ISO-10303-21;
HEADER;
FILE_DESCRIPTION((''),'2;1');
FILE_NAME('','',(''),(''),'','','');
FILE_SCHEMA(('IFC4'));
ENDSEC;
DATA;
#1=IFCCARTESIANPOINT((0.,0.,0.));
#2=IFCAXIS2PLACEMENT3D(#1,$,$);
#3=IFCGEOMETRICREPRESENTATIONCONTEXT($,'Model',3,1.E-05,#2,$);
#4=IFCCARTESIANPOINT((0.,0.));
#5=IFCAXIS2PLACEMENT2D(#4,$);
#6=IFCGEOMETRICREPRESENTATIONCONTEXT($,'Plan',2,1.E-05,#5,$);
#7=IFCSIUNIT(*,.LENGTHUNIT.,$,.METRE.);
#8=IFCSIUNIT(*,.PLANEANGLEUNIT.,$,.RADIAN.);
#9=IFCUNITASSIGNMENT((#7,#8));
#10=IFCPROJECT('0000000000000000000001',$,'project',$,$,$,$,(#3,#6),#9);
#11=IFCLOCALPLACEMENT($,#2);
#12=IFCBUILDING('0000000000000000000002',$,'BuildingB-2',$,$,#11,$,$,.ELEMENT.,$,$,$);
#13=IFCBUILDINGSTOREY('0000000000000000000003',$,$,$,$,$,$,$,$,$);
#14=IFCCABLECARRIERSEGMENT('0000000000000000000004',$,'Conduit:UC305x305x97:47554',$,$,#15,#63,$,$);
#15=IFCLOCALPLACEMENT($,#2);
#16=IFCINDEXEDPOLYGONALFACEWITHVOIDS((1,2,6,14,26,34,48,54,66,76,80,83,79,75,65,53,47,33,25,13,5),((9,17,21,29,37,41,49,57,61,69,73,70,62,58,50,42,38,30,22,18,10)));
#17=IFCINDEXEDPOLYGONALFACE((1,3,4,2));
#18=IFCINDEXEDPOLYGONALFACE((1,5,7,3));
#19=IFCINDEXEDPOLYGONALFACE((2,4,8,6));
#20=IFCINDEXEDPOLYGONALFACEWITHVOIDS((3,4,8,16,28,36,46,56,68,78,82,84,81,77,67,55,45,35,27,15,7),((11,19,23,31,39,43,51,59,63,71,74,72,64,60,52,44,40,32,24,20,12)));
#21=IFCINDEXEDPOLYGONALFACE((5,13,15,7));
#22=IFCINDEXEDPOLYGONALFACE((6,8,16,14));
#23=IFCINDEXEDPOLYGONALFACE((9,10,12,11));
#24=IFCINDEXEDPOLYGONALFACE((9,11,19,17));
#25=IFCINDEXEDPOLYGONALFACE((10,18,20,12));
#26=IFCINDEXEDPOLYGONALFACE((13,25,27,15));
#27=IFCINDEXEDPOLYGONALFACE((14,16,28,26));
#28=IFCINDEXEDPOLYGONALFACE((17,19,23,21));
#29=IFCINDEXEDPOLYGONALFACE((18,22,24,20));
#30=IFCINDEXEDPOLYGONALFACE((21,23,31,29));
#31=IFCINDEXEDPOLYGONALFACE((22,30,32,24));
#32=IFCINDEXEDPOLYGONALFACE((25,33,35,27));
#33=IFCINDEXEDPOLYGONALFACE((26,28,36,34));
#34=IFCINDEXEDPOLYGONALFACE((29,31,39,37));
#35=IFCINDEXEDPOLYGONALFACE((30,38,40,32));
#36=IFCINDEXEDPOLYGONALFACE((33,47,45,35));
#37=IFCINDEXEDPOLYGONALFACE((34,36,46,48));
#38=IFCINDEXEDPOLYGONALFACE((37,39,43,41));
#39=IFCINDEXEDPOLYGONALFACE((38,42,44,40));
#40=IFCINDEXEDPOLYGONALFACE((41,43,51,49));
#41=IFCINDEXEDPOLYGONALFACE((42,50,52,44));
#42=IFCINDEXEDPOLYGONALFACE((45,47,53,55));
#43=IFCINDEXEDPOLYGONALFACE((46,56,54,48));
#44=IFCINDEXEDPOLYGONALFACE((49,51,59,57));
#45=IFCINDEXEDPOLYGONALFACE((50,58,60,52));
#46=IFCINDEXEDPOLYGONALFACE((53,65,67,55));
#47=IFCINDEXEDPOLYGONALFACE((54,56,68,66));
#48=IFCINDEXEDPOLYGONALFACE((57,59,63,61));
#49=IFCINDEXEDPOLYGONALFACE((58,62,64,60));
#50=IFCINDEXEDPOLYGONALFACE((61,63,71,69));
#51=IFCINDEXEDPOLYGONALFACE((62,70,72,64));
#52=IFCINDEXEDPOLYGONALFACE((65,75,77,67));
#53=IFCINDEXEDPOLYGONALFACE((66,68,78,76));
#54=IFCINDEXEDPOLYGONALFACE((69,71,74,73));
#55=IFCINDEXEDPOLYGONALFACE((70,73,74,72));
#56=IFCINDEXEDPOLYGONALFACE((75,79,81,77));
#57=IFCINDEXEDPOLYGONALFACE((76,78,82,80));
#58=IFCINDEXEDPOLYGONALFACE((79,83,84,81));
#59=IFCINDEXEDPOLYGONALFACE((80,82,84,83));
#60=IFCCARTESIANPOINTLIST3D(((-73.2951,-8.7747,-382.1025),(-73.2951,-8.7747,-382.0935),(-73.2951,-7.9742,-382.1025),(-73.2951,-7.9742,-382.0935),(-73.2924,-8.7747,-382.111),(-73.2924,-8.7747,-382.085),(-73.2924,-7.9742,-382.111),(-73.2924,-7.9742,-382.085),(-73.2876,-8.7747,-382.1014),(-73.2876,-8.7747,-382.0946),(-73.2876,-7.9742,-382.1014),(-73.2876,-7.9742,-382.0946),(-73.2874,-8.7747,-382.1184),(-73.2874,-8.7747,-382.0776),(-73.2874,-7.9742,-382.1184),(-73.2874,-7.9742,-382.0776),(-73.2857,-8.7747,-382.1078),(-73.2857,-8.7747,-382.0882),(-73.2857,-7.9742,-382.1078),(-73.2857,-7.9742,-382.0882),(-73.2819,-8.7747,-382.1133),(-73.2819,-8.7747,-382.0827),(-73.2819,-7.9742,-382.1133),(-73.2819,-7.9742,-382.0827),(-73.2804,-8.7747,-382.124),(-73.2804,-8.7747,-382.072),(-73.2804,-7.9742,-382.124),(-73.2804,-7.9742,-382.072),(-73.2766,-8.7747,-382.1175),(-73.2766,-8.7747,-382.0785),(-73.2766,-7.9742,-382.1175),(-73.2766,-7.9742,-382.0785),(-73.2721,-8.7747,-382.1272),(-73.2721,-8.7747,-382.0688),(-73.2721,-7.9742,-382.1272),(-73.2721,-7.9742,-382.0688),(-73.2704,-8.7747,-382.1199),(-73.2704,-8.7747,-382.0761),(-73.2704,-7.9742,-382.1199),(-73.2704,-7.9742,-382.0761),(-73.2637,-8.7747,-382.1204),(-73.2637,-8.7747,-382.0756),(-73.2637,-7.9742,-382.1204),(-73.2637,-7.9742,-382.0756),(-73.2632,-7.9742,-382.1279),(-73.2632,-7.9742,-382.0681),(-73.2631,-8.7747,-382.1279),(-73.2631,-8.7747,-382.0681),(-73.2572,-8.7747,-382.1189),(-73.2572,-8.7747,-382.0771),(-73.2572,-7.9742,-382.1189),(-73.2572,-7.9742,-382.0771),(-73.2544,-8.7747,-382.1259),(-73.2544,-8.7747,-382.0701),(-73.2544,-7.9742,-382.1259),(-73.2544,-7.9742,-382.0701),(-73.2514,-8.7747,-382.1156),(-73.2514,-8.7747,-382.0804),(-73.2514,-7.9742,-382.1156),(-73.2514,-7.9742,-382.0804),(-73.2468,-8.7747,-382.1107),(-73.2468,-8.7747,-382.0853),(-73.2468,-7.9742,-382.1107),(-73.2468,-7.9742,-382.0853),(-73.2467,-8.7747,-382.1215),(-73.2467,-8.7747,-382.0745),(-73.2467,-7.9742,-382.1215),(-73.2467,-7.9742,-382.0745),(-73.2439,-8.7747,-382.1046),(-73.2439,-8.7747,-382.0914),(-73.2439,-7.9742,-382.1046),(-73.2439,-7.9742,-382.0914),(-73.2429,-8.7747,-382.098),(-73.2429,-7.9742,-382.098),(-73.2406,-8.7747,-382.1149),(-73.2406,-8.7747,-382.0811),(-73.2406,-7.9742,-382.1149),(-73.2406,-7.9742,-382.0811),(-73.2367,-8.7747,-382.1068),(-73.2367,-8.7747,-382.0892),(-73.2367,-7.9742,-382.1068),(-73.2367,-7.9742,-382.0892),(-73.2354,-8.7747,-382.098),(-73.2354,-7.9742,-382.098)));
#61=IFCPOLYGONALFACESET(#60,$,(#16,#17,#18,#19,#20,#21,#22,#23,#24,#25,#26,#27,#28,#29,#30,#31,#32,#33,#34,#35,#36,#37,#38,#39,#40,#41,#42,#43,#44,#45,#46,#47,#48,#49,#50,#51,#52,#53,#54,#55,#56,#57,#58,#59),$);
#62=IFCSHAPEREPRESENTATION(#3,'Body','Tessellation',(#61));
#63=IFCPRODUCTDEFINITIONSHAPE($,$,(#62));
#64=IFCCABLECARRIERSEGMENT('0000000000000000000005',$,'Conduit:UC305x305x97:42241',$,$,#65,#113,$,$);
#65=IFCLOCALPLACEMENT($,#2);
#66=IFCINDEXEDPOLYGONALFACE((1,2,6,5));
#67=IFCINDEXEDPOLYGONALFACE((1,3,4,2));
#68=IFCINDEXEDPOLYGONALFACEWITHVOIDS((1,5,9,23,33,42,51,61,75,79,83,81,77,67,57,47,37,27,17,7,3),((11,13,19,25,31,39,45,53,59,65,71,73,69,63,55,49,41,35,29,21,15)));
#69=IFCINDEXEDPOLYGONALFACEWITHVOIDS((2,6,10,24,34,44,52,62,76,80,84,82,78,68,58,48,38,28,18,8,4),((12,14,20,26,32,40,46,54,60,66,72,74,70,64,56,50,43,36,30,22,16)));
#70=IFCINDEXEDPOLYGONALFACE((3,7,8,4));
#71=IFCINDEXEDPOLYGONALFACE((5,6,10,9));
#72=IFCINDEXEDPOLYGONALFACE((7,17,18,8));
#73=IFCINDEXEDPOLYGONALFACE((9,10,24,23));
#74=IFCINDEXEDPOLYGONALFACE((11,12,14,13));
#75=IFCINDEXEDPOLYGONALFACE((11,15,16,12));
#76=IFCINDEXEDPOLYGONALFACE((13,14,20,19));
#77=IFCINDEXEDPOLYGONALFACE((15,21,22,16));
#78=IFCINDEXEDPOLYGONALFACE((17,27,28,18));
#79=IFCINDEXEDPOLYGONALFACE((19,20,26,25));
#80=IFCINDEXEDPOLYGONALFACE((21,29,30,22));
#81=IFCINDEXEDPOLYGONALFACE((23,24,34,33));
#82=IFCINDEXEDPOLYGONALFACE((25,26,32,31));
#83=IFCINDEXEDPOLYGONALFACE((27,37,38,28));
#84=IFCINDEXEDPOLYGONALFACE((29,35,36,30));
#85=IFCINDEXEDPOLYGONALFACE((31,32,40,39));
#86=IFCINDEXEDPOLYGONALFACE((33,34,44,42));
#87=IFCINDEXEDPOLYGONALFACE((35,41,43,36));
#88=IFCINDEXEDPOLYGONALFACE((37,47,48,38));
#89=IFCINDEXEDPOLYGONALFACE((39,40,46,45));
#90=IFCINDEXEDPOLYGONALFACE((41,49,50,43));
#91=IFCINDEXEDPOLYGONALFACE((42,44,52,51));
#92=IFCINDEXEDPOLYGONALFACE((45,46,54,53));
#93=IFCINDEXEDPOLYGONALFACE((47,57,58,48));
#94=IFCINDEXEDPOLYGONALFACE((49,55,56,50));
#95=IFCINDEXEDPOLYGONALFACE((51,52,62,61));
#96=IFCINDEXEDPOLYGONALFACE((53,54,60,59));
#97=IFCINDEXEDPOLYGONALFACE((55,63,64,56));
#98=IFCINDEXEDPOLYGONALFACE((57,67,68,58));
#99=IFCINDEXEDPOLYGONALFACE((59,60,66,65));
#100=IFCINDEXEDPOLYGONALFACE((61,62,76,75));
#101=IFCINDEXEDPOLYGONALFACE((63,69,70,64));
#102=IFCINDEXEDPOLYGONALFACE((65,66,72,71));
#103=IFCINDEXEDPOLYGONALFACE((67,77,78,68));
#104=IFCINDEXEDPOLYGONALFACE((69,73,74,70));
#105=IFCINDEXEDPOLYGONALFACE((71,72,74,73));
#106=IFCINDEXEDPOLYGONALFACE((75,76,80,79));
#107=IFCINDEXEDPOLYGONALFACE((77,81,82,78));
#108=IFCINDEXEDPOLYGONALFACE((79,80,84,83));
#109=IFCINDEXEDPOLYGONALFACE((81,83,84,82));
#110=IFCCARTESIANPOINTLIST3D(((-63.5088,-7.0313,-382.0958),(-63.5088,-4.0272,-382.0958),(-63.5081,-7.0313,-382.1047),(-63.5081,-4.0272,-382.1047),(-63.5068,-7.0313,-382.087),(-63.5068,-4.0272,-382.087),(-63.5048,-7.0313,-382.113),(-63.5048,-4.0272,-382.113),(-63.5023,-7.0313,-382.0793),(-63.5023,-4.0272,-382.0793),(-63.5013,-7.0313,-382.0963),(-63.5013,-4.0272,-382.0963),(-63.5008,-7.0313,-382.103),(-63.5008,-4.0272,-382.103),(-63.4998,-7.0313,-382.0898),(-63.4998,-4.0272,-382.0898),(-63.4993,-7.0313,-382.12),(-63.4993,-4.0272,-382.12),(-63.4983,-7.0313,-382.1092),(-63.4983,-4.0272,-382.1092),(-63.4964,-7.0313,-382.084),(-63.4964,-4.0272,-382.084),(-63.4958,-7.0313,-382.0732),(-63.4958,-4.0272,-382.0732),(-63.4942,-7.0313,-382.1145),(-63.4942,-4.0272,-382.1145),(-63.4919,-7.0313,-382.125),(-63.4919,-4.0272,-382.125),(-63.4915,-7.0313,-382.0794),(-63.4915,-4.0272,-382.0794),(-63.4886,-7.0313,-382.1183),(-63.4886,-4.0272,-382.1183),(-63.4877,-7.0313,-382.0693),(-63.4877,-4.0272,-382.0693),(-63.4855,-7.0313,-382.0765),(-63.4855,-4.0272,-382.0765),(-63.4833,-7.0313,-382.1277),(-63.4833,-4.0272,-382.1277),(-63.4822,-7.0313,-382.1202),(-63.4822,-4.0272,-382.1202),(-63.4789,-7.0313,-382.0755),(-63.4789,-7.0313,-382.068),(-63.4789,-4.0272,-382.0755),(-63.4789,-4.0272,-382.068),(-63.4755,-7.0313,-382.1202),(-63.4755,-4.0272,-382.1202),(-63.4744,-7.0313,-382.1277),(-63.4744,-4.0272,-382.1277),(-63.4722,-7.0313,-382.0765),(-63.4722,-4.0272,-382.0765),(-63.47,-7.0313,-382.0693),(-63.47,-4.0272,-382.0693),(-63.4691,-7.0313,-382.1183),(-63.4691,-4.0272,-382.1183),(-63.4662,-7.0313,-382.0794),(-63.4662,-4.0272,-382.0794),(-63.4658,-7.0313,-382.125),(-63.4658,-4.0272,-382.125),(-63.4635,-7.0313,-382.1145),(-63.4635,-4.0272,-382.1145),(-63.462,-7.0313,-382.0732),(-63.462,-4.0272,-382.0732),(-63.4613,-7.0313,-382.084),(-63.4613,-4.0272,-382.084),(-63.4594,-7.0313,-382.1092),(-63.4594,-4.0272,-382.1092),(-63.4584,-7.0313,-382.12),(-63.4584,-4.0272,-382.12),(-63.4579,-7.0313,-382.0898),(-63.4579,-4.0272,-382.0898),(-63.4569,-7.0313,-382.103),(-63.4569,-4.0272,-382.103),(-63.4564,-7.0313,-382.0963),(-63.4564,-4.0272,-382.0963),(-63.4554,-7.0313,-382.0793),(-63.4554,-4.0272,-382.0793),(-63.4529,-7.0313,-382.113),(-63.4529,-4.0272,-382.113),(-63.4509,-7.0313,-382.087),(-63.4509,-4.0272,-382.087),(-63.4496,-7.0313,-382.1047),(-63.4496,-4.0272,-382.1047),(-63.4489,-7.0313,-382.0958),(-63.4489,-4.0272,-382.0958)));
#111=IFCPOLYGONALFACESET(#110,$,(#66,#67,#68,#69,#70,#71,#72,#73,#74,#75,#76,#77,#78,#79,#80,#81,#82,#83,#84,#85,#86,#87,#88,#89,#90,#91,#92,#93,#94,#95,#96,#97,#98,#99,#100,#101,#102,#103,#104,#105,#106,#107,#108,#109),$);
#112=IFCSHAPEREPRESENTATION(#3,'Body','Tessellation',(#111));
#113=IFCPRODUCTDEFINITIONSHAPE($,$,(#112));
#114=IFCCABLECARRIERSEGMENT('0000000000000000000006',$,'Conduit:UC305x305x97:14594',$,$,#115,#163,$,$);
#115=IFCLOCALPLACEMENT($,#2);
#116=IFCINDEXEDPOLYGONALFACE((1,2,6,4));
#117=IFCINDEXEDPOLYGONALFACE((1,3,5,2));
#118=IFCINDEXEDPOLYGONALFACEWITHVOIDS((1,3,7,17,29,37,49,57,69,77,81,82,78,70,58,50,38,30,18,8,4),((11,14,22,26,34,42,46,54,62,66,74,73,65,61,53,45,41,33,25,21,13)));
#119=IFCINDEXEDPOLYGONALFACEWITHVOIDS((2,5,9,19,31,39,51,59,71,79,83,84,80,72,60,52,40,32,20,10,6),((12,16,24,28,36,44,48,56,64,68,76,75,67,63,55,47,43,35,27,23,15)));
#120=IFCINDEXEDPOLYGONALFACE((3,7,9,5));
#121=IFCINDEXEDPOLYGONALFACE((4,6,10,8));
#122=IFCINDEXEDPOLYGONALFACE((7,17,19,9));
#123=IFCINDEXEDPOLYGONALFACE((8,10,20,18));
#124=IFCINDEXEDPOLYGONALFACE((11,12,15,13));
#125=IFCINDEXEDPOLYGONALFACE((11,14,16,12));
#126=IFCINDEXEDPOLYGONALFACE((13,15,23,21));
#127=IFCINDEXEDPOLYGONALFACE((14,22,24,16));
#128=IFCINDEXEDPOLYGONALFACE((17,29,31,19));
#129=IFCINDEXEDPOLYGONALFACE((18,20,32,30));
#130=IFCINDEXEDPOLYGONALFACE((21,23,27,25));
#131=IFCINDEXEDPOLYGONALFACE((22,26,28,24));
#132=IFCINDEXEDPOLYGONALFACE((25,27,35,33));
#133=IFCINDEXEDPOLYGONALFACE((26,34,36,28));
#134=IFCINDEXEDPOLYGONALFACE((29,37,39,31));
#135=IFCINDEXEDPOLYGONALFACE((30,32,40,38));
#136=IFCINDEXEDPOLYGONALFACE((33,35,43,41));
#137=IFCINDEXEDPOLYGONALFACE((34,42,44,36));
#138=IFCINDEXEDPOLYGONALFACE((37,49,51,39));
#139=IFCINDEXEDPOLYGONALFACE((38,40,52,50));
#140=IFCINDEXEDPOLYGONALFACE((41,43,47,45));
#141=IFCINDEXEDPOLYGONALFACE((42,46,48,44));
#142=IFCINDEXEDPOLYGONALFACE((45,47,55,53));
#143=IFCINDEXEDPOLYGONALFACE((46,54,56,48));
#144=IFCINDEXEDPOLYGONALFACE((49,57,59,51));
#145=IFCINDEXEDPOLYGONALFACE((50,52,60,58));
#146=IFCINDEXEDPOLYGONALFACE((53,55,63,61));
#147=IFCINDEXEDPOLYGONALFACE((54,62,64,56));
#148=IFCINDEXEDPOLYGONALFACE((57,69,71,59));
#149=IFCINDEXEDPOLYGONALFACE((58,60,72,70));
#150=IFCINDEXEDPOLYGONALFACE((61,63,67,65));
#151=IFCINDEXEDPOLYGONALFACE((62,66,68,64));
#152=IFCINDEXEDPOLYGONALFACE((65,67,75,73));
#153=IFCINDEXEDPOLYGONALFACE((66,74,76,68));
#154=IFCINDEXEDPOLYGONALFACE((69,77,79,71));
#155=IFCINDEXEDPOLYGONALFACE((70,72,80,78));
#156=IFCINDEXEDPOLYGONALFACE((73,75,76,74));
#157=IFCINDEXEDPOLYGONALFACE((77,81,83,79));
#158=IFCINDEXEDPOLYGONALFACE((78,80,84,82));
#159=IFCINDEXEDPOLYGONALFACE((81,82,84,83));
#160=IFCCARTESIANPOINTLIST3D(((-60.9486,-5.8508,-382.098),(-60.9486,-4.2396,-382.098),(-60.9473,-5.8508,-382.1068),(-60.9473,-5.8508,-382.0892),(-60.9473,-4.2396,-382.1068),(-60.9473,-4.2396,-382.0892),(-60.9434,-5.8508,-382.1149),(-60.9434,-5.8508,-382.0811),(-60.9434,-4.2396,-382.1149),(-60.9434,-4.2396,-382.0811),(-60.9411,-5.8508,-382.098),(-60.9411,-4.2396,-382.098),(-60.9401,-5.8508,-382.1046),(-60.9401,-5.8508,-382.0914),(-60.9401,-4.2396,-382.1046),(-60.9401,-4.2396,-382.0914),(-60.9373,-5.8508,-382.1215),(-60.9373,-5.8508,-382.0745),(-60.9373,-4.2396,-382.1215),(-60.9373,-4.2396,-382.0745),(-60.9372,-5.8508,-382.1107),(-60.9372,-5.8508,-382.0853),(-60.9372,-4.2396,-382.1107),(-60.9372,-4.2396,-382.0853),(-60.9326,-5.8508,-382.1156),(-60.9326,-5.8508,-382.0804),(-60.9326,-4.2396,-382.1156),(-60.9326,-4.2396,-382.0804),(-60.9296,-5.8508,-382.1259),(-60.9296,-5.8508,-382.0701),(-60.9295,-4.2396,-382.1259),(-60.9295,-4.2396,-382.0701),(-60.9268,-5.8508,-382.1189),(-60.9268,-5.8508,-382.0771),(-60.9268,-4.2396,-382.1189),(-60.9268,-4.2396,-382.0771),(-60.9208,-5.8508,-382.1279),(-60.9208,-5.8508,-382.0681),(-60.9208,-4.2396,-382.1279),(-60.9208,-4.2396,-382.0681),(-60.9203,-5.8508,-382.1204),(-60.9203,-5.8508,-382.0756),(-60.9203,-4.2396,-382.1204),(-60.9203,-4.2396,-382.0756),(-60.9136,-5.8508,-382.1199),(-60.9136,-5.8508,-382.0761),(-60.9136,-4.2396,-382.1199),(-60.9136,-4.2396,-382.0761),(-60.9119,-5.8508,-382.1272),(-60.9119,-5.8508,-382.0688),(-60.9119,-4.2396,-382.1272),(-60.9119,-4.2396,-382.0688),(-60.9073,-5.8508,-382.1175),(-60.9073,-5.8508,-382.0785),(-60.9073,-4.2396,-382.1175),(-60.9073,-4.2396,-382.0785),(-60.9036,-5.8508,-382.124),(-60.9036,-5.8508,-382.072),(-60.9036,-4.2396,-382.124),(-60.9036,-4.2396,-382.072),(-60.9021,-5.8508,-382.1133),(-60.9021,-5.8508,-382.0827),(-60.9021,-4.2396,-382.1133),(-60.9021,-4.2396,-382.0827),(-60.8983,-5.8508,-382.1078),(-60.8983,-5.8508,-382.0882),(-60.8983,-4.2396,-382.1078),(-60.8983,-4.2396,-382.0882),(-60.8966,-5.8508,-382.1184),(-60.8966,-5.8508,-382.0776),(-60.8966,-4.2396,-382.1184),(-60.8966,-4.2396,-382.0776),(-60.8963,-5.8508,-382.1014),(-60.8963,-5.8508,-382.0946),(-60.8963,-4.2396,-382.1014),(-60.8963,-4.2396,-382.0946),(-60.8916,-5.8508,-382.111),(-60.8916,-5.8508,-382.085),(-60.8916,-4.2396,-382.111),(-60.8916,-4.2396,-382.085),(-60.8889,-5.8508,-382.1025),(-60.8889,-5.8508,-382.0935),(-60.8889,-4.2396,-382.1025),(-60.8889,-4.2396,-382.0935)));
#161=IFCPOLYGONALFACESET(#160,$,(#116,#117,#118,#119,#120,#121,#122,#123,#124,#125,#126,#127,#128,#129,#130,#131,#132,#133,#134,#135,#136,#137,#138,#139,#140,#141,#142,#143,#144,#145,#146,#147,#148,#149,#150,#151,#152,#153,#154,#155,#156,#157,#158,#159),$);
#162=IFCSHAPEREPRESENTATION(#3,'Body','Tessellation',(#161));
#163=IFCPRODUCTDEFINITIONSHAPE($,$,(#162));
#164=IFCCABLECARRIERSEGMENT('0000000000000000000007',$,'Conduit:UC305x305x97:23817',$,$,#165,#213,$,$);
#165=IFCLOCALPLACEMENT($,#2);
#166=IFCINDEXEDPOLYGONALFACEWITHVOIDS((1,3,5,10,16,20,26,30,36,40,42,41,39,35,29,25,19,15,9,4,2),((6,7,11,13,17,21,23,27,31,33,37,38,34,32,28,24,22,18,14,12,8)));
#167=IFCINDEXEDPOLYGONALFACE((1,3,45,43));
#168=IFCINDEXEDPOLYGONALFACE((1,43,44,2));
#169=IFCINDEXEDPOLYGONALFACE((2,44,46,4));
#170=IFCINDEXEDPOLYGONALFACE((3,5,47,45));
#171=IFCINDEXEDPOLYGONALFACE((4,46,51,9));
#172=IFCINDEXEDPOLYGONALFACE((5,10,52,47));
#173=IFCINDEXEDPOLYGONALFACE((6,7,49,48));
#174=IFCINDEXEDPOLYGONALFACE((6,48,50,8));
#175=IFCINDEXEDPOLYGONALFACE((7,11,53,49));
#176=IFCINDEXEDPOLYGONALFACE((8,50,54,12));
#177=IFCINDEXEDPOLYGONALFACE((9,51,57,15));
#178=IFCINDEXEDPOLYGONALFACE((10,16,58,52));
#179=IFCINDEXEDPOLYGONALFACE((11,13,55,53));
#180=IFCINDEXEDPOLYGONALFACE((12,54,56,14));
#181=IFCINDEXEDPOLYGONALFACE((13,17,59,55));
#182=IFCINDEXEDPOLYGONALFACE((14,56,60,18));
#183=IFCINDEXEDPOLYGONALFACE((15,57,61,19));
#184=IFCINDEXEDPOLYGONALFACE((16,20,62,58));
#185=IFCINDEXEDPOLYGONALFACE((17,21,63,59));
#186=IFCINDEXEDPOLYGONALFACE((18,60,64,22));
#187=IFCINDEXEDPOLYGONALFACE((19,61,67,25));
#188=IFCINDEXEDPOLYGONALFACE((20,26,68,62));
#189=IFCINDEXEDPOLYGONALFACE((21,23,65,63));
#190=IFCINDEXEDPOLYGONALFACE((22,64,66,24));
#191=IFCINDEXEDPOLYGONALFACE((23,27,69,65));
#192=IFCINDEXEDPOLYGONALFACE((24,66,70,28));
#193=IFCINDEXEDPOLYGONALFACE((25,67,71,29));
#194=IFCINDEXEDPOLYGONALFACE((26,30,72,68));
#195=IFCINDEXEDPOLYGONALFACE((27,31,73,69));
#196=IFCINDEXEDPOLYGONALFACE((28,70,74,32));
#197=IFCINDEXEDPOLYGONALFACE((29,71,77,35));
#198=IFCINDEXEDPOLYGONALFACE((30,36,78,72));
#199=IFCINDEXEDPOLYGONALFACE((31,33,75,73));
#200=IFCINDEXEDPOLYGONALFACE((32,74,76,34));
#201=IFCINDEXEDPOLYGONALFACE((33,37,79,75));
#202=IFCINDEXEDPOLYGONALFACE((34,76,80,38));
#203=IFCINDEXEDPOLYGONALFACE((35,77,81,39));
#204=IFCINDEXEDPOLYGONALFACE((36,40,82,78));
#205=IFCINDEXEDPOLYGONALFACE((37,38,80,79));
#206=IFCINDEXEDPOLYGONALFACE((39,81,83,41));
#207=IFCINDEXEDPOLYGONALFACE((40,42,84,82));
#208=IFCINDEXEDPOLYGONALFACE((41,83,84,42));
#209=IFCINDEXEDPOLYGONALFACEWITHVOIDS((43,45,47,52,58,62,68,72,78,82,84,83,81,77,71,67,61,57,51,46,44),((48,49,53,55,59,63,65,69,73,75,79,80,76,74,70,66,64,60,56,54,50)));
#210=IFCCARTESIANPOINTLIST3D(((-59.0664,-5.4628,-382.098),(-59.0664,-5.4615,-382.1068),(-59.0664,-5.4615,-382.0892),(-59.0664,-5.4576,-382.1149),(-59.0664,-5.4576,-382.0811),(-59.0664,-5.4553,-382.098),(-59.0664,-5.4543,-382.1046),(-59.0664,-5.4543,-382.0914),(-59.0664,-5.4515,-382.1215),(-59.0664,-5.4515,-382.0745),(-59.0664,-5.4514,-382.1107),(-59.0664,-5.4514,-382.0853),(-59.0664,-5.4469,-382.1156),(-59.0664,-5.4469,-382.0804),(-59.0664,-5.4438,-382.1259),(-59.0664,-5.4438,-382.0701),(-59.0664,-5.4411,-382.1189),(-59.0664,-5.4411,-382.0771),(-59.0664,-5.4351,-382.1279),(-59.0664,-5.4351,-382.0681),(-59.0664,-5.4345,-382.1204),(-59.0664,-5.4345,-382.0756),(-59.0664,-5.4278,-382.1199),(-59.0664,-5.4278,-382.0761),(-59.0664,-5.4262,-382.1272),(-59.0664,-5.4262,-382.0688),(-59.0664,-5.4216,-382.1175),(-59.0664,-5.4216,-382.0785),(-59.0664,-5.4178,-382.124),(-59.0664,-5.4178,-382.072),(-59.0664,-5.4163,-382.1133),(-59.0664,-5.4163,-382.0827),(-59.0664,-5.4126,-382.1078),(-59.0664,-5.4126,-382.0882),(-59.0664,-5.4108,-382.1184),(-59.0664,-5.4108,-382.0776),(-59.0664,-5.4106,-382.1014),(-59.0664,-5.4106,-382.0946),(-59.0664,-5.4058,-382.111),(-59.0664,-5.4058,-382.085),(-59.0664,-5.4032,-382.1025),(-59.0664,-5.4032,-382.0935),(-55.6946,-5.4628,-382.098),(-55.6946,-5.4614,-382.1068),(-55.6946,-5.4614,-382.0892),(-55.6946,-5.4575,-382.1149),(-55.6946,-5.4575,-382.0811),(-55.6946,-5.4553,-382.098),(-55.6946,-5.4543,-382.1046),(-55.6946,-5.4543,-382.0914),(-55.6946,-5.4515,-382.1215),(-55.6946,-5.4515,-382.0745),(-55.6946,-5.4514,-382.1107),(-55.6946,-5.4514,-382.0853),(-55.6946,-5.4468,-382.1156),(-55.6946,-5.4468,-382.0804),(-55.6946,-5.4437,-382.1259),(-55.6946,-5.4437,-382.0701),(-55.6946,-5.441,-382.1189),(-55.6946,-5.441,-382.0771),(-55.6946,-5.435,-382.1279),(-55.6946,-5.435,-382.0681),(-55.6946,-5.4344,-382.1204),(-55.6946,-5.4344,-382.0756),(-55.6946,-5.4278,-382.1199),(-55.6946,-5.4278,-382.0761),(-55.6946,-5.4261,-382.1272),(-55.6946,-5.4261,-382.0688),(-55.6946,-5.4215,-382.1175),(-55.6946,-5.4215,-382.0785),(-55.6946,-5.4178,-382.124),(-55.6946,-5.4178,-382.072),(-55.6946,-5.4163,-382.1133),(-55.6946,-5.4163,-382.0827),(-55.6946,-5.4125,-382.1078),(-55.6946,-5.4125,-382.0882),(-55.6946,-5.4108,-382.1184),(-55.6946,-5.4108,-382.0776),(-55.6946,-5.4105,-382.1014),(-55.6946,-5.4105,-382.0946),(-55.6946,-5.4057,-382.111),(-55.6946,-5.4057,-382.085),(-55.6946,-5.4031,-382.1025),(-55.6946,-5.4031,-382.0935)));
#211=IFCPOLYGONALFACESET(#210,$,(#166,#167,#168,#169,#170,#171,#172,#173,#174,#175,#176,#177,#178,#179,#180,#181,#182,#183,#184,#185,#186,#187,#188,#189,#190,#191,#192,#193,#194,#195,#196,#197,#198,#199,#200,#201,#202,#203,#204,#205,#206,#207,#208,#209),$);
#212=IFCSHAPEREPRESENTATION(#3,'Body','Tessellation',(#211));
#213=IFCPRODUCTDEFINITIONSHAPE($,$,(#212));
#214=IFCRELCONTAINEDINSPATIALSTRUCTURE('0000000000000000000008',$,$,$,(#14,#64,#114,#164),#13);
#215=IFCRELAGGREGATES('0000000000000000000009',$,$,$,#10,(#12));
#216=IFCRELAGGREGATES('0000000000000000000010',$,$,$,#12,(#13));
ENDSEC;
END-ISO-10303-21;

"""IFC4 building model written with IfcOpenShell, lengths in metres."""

from ifc_helpers import new_model, entity, si_unit, origin, origin_2d, place, context, project, spatial, element, save


model = new_model("IFC4")

# Units and contexts
model_context = context("Model", 3, precision=1e-05, world=origin())
plan_context = context("Plan", 2, precision=1e-05, world=origin_2d())
ifc_project = project(units=[si_unit("LENGTHUNIT", "METRE"), si_unit("PLANEANGLEUNIT", "RADIAN")], contexts=[model_context, plan_context])

# Building, storey
building_placement = place(None, origin())
building = spatial("IfcBuilding", under=ifc_project, at=building_placement, Name="BuildingB-2", CompositionType="ELEMENT")
storey = spatial("IfcBuildingStorey", under=building)

# Cable carrier segments
element("IfcCableCarrierSegment", 1, inside=storey, Name="Conduit:UC305x305x97:47554", context=model_context, shape_type="AdvancedSweptSolid", body=[
    entity("IfcSweptDiskSolid", entity("IfcCompositeCurve", [entity("IfcCompositeCurveSegment", "CONTINUOUS", False, entity("IfcPolyline", [entity("IfcCartesianPoint", [73.2654, 7.9742, 382.098]), entity("IfcCartesianPoint", [73.2654, 8.7747, 382.098])]))], False), 0.03, 0.0225),
])
element("IfcCableCarrierSegment", 2, inside=storey, Name="Conduit:UC305x305x97:42241", context=model_context, shape_type="AdvancedSweptSolid", body=[
    entity("IfcSweptDiskSolid", entity("IfcCompositeCurve", [entity("IfcCompositeCurveSegment", "CONTINUOUS", False, entity("IfcPolyline", [entity("IfcCartesianPoint", [63.4789, 4.0272, 382.098]), entity("IfcCartesianPoint", [63.4789, 7.0313, 382.098])]))], False), 0.03, 0.0225),
])
element("IfcCableCarrierSegment", 3, inside=storey, Name="Conduit:UC305x305x97:14594", context=model_context, shape_type="AdvancedSweptSolid", body=[
    entity("IfcSweptDiskSolid", entity("IfcCompositeCurve", [entity("IfcCompositeCurveSegment", "CONTINUOUS", False, entity("IfcPolyline", [entity("IfcCartesianPoint", [60.9186, 5.8508, 382.098]), entity("IfcCartesianPoint", [60.9186, 4.2396, 382.098])]))], False), 0.03, 0.0225),
])
element("IfcCableCarrierSegment", 4, inside=storey, Name="Conduit:UC305x305x97:23817", context=model_context, shape_type="AdvancedSweptSolid", body=[
    entity("IfcSweptDiskSolid", entity("IfcCompositeCurve", [entity("IfcCompositeCurveSegment", "CONTINUOUS", False, entity("IfcPolyline", [entity("IfcCartesianPoint", [59.0664, 5.4328, 382.098]), entity("IfcCartesianPoint", [55.6946, 5.4328, 382.098])]))], False), 0.03, 0.0225),
])

save(model, "model.ifc")
